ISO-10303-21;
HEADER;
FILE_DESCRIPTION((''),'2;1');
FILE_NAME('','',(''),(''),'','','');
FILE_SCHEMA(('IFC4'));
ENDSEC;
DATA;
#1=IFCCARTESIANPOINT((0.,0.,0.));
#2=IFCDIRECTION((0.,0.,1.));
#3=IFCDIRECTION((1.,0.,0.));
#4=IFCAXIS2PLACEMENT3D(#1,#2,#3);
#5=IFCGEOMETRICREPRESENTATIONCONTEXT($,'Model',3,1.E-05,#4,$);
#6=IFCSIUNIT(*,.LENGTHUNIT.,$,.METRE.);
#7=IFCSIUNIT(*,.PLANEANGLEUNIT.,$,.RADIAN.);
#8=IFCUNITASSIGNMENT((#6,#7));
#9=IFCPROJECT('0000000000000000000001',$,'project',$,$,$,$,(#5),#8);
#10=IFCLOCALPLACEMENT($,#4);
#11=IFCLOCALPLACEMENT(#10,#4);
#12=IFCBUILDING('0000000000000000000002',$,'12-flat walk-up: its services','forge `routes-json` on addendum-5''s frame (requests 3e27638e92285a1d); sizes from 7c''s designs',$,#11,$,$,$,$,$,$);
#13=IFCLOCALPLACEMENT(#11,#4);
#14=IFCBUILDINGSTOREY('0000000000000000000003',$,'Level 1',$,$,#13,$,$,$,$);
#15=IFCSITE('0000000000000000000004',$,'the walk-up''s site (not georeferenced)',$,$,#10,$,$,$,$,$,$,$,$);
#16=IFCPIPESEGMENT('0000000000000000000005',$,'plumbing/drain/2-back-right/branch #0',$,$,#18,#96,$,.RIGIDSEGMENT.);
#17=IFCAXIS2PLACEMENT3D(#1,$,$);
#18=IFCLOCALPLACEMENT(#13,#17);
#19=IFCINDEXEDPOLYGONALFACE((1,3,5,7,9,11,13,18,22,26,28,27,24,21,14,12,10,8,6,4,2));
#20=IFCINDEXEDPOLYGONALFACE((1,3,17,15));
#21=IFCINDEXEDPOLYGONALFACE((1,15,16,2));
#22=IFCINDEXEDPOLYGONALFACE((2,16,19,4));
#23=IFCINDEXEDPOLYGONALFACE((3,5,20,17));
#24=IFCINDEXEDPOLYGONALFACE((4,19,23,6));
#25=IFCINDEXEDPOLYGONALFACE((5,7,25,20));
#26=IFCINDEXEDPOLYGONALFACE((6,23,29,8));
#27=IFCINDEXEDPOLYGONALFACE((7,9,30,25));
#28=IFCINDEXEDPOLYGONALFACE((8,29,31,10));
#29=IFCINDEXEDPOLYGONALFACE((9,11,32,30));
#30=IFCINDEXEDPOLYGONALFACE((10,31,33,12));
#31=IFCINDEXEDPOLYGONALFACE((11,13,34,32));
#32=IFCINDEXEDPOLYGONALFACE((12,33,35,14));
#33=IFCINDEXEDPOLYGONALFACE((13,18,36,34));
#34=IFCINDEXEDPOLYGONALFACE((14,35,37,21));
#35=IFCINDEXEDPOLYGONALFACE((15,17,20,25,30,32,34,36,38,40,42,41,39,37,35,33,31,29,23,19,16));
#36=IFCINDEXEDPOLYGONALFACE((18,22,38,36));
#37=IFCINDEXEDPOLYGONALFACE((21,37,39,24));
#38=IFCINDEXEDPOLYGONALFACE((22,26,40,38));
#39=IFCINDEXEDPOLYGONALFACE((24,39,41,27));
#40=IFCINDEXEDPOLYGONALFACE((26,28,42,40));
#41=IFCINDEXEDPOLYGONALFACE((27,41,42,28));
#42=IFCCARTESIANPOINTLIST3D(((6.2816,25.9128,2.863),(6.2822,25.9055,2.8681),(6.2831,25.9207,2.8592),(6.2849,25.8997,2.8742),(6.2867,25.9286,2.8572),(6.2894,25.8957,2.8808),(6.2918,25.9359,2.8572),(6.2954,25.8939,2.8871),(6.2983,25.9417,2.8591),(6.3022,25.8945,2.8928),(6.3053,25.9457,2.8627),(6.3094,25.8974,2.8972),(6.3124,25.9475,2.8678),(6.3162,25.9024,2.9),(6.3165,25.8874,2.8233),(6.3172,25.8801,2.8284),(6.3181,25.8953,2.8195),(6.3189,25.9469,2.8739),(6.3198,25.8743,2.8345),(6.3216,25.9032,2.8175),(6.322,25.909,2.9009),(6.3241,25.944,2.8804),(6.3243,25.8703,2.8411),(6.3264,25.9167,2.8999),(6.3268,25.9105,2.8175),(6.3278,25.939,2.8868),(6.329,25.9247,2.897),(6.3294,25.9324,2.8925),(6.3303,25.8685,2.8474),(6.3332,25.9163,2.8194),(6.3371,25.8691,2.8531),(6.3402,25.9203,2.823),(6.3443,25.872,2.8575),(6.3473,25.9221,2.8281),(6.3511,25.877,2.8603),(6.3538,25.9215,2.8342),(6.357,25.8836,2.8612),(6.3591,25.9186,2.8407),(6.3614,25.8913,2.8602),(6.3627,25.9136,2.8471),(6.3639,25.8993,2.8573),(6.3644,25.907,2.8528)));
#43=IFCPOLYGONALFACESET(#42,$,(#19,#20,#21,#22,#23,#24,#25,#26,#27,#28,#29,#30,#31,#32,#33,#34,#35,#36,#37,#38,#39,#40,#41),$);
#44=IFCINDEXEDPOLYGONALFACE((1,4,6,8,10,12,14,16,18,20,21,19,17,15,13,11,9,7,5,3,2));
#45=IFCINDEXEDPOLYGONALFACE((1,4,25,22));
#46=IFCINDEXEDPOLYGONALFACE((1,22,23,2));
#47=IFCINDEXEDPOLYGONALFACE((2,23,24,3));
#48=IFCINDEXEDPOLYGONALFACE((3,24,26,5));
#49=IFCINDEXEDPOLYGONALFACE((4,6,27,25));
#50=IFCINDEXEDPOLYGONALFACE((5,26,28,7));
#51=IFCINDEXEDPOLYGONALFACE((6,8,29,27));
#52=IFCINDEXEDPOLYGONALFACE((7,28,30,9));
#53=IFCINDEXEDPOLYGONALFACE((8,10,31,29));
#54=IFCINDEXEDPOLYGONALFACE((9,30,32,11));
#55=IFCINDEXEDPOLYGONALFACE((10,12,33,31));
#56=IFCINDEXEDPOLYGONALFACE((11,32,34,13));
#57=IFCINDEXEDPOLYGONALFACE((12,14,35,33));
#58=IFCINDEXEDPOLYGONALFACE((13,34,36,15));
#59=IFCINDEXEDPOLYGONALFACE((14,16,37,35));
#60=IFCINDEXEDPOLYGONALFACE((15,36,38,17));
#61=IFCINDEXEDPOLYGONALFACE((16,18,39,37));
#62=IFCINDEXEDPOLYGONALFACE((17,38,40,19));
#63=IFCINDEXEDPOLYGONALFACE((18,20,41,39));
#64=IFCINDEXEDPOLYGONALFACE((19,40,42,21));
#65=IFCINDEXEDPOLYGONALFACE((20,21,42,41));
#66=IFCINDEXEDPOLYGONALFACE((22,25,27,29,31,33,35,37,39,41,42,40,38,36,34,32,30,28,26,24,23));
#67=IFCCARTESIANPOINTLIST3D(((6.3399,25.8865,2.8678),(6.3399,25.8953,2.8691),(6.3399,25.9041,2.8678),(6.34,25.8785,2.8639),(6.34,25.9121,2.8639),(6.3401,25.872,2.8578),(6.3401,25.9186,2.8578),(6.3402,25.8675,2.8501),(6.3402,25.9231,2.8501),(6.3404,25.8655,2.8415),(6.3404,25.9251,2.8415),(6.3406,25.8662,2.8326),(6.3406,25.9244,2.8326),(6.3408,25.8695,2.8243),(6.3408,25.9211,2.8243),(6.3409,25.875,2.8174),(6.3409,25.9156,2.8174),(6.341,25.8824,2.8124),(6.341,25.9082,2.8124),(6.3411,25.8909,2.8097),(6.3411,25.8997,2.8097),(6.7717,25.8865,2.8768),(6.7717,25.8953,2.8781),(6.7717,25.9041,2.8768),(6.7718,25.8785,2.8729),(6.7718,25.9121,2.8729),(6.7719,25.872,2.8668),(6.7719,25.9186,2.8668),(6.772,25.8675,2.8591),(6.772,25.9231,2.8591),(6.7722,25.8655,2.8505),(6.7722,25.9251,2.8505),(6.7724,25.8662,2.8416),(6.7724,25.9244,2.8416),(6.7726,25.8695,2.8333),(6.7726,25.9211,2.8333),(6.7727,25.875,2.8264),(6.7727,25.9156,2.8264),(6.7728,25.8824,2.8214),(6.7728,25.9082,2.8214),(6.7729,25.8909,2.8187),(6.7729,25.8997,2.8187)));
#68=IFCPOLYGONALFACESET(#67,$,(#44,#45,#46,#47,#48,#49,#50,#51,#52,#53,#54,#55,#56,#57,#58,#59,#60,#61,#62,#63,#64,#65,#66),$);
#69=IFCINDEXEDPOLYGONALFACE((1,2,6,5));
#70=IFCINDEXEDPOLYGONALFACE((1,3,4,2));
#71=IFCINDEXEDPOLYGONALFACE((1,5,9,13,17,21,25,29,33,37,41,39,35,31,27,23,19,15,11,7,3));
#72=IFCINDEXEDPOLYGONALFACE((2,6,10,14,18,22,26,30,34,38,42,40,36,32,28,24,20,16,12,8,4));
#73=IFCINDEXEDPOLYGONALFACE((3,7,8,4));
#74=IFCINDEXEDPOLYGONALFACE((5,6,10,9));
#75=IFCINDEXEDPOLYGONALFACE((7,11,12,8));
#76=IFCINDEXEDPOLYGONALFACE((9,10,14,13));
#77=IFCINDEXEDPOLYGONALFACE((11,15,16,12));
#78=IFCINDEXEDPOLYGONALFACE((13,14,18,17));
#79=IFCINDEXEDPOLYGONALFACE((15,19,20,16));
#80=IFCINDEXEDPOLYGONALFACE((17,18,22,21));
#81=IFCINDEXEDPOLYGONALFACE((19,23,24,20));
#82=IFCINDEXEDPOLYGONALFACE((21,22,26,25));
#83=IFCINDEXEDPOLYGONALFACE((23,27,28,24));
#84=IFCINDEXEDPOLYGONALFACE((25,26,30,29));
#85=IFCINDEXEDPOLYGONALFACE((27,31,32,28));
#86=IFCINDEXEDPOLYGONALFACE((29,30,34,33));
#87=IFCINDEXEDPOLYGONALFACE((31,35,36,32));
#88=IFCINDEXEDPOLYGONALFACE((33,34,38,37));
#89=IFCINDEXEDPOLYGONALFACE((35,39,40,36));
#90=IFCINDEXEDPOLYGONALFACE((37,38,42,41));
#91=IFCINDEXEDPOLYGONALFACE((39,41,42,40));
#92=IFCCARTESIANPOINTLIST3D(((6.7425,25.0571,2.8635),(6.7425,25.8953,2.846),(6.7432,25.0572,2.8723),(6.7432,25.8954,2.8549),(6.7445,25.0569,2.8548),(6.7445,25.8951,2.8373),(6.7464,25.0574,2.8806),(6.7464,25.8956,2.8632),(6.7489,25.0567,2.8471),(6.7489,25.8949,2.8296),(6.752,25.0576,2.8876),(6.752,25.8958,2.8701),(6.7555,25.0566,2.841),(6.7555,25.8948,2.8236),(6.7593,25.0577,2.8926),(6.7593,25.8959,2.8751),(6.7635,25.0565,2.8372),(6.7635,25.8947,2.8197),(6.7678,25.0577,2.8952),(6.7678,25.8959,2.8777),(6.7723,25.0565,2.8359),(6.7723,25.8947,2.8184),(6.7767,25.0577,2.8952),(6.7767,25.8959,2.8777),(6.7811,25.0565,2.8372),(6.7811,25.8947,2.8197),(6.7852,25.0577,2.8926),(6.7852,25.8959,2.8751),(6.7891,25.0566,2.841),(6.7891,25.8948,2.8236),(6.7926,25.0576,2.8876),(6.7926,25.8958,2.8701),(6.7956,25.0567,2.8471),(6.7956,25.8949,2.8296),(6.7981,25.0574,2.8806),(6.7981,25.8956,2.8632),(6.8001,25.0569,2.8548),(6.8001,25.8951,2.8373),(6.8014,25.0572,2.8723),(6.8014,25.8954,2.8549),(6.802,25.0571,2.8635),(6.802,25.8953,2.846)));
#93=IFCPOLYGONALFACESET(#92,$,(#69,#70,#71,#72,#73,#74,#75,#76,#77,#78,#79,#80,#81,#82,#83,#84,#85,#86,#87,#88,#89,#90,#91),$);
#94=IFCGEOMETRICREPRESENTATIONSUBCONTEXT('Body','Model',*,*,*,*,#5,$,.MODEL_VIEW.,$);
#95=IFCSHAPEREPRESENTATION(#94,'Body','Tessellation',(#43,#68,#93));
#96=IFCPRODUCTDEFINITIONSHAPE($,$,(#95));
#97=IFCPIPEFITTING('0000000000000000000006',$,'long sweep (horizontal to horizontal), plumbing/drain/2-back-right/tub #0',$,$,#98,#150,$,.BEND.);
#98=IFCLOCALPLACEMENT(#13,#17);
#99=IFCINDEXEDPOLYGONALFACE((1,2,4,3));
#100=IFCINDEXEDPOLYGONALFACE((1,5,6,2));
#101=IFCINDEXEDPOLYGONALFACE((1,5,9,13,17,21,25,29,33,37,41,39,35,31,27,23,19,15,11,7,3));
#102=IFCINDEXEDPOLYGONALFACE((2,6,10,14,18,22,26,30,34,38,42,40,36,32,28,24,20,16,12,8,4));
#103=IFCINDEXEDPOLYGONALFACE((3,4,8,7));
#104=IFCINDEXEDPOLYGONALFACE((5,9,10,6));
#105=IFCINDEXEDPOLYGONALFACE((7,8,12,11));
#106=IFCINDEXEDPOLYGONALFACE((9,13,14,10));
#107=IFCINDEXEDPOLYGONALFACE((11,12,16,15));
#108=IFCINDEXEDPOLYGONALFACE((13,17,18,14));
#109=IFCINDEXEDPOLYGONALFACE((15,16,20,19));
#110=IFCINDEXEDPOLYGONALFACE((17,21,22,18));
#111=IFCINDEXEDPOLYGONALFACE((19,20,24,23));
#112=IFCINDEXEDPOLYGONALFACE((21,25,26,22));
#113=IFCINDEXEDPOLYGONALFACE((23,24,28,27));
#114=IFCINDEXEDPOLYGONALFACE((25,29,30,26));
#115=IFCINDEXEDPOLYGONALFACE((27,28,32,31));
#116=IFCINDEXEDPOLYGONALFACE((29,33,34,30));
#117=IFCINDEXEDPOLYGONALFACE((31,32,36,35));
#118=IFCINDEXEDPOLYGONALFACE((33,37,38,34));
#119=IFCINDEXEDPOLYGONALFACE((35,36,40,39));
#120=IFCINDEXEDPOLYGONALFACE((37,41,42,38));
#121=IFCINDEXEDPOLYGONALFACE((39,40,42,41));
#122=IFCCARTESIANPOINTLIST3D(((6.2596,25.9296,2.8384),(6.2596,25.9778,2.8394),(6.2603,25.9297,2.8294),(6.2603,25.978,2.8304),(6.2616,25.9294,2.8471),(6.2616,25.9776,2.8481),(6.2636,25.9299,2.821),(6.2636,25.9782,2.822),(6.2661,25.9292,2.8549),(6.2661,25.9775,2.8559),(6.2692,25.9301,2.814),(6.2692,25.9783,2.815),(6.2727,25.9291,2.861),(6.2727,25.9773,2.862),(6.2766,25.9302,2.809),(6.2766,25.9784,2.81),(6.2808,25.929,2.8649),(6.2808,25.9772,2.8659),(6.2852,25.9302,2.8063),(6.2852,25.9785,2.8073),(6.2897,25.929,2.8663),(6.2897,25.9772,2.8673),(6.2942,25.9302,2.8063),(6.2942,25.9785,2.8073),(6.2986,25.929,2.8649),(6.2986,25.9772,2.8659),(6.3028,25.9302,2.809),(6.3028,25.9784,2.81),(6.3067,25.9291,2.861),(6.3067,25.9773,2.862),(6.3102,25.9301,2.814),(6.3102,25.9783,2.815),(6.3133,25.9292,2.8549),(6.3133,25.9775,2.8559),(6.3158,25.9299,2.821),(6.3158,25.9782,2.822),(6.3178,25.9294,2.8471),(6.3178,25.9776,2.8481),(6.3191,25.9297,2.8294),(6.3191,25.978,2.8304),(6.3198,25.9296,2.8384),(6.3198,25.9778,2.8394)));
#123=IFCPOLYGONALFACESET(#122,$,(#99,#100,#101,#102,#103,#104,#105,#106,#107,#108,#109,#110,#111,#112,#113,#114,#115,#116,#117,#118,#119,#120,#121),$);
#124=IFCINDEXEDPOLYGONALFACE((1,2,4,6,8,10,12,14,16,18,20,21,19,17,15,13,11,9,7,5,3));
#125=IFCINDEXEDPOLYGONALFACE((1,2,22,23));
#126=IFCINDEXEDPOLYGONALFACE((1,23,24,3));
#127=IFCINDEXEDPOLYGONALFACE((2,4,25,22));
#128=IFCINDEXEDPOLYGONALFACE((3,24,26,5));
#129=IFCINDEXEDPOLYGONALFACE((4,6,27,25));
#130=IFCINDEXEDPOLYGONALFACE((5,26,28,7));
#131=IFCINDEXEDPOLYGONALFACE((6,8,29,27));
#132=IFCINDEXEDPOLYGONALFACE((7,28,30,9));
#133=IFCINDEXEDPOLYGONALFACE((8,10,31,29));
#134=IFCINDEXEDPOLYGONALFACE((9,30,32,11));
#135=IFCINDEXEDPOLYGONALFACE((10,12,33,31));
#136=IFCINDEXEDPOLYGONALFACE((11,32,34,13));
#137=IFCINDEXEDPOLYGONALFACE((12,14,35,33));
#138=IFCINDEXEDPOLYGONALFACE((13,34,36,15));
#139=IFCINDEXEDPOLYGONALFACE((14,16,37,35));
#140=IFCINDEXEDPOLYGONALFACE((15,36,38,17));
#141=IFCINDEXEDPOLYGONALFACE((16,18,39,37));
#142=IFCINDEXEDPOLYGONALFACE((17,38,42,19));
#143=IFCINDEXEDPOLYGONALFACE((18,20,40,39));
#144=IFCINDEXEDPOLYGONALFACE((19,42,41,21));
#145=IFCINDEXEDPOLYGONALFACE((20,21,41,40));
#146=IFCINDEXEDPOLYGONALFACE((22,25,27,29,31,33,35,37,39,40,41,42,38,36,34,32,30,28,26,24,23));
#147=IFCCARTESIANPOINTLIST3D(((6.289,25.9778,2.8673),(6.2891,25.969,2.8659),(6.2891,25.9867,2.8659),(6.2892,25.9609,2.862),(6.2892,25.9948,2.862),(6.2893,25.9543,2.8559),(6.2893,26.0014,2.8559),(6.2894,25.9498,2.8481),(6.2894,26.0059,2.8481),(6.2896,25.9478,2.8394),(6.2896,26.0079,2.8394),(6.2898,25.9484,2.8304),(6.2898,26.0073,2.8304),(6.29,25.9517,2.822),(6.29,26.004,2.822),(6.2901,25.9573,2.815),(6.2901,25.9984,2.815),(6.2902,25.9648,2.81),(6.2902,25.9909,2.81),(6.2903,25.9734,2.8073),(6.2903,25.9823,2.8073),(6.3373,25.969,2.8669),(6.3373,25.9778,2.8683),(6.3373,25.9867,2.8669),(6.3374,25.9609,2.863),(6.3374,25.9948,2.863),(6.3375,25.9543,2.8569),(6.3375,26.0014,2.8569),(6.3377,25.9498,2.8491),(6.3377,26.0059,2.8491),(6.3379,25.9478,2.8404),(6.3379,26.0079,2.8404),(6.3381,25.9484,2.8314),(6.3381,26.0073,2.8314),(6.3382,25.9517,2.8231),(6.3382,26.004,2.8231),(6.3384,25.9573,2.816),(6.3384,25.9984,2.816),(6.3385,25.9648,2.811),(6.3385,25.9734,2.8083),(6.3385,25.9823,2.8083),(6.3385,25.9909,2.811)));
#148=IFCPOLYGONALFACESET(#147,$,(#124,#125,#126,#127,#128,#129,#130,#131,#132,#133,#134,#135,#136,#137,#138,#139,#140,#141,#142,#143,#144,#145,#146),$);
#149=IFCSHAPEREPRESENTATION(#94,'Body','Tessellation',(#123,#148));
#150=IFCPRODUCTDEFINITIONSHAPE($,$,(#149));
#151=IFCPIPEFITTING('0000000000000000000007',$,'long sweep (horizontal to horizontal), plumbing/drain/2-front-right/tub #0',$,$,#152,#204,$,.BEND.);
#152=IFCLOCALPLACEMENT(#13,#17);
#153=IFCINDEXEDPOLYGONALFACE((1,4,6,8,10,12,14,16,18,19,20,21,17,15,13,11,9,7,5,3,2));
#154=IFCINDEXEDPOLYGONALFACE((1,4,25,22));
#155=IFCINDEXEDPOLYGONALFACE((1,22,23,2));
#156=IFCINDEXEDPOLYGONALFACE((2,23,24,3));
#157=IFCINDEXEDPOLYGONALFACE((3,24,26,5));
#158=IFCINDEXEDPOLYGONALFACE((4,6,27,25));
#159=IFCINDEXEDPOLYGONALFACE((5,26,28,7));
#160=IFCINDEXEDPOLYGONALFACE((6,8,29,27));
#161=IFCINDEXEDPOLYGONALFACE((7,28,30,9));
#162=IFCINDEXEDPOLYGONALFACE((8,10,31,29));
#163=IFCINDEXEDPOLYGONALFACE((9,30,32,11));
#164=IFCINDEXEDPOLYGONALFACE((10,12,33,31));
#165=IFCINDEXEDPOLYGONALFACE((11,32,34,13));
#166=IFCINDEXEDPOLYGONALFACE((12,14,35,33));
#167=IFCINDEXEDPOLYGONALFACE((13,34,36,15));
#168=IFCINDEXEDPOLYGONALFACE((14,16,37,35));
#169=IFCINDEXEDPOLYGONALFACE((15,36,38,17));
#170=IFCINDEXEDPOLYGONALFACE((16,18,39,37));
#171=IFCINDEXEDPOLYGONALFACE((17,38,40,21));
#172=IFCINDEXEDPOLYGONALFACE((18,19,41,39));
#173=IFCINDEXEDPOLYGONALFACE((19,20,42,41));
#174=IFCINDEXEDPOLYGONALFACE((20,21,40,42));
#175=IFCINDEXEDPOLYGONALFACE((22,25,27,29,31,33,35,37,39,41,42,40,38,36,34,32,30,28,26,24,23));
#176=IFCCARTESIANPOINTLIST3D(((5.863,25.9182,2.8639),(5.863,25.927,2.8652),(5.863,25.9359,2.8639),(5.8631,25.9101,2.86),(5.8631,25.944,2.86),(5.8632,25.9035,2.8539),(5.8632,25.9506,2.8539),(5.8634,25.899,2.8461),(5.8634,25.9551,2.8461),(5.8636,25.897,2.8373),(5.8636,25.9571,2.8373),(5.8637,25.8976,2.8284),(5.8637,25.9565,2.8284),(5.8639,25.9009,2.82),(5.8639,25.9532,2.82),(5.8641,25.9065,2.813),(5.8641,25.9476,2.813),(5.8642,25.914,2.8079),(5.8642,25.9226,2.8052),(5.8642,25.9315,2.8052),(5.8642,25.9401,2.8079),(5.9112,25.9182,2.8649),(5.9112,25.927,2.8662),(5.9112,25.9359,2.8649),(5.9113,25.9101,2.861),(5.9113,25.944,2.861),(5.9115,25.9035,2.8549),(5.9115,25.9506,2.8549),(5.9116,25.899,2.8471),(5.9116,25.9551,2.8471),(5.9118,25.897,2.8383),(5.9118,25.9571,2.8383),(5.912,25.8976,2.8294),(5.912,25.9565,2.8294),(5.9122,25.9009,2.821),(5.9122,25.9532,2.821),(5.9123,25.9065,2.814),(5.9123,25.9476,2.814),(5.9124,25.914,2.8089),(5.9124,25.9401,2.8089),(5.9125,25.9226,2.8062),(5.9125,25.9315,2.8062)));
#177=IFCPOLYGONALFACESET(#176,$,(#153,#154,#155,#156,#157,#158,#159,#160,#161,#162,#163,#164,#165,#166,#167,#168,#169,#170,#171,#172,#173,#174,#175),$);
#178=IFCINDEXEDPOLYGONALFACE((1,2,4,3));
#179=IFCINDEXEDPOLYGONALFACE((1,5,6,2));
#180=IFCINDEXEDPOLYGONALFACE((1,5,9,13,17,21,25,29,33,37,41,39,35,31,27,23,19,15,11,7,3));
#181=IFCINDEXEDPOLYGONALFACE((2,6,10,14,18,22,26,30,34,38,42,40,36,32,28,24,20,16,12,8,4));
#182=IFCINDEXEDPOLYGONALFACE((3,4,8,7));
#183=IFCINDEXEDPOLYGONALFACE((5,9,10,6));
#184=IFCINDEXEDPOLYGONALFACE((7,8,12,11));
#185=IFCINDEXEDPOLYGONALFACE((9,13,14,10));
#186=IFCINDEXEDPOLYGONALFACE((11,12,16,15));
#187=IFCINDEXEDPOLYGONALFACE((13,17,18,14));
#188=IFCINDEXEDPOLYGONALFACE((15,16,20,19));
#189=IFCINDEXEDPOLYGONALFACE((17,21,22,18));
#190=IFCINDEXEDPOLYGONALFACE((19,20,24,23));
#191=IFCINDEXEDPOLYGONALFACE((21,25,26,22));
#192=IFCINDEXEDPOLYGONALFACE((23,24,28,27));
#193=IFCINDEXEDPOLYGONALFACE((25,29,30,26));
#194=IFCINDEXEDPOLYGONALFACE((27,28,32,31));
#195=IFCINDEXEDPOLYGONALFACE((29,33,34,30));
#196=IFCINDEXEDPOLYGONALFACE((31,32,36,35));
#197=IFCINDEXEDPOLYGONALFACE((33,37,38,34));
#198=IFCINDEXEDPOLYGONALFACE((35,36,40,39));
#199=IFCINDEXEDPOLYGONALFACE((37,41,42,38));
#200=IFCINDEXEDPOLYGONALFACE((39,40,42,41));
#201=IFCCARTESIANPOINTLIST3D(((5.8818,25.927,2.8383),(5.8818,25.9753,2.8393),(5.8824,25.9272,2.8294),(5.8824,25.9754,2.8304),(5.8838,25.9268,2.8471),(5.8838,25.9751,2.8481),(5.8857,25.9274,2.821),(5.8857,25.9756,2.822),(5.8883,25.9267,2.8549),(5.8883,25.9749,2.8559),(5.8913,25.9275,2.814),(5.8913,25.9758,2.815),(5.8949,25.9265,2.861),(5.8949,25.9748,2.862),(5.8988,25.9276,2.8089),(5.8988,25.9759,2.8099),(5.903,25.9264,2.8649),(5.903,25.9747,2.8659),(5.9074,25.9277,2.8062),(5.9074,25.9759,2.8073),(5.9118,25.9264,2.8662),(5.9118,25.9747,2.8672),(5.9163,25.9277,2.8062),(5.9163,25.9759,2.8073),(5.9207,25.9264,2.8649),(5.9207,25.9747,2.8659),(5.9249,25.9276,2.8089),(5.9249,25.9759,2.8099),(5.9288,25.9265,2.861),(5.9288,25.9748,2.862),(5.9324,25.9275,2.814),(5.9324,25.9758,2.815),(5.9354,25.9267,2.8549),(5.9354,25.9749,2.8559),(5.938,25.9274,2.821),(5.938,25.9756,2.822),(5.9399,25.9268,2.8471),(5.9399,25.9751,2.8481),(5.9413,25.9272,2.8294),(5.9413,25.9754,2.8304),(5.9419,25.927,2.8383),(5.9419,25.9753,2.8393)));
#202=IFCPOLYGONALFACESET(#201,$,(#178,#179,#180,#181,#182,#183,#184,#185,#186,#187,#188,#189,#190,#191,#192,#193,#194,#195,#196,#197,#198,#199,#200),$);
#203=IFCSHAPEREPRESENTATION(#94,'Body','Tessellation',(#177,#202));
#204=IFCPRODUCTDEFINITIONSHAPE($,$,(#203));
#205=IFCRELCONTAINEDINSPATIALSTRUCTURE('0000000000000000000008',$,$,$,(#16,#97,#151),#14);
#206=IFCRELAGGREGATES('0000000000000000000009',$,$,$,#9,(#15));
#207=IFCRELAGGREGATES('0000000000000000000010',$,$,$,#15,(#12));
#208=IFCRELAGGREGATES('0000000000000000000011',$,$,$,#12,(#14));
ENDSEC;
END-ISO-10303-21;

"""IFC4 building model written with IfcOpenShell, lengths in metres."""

from ifc_helpers import new_model, entity, si_unit, frame, origin_with_axes, place, context, subcontext, project, spatial, element, save


model = new_model("IFC4")

# Units and contexts
model_context = context("Model", 3, precision=1e-05, world=origin_with_axes())
body_context = subcontext(model_context, "Body", "Model", "MODEL_VIEW")
ifc_project = project(units=[si_unit("LENGTHUNIT", "METRE"), si_unit("PLANEANGLEUNIT", "RADIAN")], contexts=[model_context])

# Site, building, storey
site_placement = place(None, origin_with_axes())
site = spatial("IfcSite", under=ifc_project, at=site_placement, Name="the walk-up's site (not georeferenced)")
building_placement = place(site_placement, origin_with_axes())
building = spatial("IfcBuilding", under=site, at=building_placement, Name="12-flat walk-up: its services", Description="forge `routes-json` on addendum-5's frame (requests 3e27638e92285a1d); sizes from 7c's designs")
storey_placement = place(building_placement, origin_with_axes())
storey = spatial("IfcBuildingStorey", under=building, at=storey_placement, Name="Level 1")

# Pipe segment
pipe_segment_1_placement = place(storey_placement, frame((6.3056, 25.9207, 2.8789), z_axis=(0.0, 0.0, 1.0), x_axis=(1.0, 0.0, 0.0)))
element("IfcPipeSegment", 1, at=pipe_segment_1_placement, inside=storey, Name="plumbing/drain/2-back-right/branch #0", PredefinedType="RIGIDSEGMENT", context=body_context, shape_type="AdvancedSweptSolid", body=[
    entity("IfcSweptDiskSolid", entity("IfcPolyline", [entity("IfcCartesianPoint", [0.0, 0.0, 0.0]), entity("IfcCartesianPoint", [0.0349, -0.0254, -0.0397])]), 0.0298),
    entity("IfcSweptDiskSolid", entity("IfcPolyline", [entity("IfcCartesianPoint", [0.0349, -0.0254, -0.0397]), entity("IfcCartesianPoint", [0.4667, -0.0254, -0.0307])]), 0.0298),
    entity("IfcSweptDiskSolid", entity("IfcPolyline", [entity("IfcCartesianPoint", [0.4667, -0.0254, -0.0307]), entity("IfcCartesianPoint", [0.4667, -0.8636, -0.0132])]), 0.0298),
])

# Pipe fitting
pipe_fitting_1_placement = place(storey_placement, frame((6.2897, 25.9296, 2.8361), z_axis=(0.0, 0.0, 1.0), x_axis=(1.0, 0.0, 0.0)))
element("IfcPipeFitting", 2, at=pipe_fitting_1_placement, inside=storey, Name="long sweep (horizontal to horizontal), plumbing/drain/2-back-right/tub #0", PredefinedType="BEND", context=body_context, shape_type="AdvancedSweptSolid", body=[
    entity("IfcSweptDiskSolid", entity("IfcPolyline", [entity("IfcCartesianPoint", [0.0, 0.0, 0.0]), entity("IfcCartesianPoint", [0.0, 0.0482, 0.001])]), 0.0302),
    entity("IfcSweptDiskSolid", entity("IfcPolyline", [entity("IfcCartesianPoint", [0.0, 0.0482, 0.001]), entity("IfcCartesianPoint", [0.0482, 0.0482, 0.002])]), 0.0302),
])

# Pipe fitting
pipe_fitting_2_placement = place(storey_placement, frame((5.8636, 25.9271, 2.8351), z_axis=(0.0, 0.0, 1.0), x_axis=(1.0, 0.0, 0.0)))
element("IfcPipeFitting", 3, at=pipe_fitting_2_placement, inside=storey, Name="long sweep (horizontal to horizontal), plumbing/drain/2-front-right/tub #0", PredefinedType="BEND", context=body_context, shape_type="AdvancedSweptSolid", body=[
    entity("IfcSweptDiskSolid", entity("IfcPolyline", [entity("IfcCartesianPoint", [0.0, 0.0, 0.0]), entity("IfcCartesianPoint", [0.0482, 0.0, 0.001])]), 0.0302),
    entity("IfcSweptDiskSolid", entity("IfcPolyline", [entity("IfcCartesianPoint", [0.0482, 0.0, 0.001]), entity("IfcCartesianPoint", [0.0482, 0.0482, 0.002])]), 0.0302),
])

save(model, "model.ifc")
